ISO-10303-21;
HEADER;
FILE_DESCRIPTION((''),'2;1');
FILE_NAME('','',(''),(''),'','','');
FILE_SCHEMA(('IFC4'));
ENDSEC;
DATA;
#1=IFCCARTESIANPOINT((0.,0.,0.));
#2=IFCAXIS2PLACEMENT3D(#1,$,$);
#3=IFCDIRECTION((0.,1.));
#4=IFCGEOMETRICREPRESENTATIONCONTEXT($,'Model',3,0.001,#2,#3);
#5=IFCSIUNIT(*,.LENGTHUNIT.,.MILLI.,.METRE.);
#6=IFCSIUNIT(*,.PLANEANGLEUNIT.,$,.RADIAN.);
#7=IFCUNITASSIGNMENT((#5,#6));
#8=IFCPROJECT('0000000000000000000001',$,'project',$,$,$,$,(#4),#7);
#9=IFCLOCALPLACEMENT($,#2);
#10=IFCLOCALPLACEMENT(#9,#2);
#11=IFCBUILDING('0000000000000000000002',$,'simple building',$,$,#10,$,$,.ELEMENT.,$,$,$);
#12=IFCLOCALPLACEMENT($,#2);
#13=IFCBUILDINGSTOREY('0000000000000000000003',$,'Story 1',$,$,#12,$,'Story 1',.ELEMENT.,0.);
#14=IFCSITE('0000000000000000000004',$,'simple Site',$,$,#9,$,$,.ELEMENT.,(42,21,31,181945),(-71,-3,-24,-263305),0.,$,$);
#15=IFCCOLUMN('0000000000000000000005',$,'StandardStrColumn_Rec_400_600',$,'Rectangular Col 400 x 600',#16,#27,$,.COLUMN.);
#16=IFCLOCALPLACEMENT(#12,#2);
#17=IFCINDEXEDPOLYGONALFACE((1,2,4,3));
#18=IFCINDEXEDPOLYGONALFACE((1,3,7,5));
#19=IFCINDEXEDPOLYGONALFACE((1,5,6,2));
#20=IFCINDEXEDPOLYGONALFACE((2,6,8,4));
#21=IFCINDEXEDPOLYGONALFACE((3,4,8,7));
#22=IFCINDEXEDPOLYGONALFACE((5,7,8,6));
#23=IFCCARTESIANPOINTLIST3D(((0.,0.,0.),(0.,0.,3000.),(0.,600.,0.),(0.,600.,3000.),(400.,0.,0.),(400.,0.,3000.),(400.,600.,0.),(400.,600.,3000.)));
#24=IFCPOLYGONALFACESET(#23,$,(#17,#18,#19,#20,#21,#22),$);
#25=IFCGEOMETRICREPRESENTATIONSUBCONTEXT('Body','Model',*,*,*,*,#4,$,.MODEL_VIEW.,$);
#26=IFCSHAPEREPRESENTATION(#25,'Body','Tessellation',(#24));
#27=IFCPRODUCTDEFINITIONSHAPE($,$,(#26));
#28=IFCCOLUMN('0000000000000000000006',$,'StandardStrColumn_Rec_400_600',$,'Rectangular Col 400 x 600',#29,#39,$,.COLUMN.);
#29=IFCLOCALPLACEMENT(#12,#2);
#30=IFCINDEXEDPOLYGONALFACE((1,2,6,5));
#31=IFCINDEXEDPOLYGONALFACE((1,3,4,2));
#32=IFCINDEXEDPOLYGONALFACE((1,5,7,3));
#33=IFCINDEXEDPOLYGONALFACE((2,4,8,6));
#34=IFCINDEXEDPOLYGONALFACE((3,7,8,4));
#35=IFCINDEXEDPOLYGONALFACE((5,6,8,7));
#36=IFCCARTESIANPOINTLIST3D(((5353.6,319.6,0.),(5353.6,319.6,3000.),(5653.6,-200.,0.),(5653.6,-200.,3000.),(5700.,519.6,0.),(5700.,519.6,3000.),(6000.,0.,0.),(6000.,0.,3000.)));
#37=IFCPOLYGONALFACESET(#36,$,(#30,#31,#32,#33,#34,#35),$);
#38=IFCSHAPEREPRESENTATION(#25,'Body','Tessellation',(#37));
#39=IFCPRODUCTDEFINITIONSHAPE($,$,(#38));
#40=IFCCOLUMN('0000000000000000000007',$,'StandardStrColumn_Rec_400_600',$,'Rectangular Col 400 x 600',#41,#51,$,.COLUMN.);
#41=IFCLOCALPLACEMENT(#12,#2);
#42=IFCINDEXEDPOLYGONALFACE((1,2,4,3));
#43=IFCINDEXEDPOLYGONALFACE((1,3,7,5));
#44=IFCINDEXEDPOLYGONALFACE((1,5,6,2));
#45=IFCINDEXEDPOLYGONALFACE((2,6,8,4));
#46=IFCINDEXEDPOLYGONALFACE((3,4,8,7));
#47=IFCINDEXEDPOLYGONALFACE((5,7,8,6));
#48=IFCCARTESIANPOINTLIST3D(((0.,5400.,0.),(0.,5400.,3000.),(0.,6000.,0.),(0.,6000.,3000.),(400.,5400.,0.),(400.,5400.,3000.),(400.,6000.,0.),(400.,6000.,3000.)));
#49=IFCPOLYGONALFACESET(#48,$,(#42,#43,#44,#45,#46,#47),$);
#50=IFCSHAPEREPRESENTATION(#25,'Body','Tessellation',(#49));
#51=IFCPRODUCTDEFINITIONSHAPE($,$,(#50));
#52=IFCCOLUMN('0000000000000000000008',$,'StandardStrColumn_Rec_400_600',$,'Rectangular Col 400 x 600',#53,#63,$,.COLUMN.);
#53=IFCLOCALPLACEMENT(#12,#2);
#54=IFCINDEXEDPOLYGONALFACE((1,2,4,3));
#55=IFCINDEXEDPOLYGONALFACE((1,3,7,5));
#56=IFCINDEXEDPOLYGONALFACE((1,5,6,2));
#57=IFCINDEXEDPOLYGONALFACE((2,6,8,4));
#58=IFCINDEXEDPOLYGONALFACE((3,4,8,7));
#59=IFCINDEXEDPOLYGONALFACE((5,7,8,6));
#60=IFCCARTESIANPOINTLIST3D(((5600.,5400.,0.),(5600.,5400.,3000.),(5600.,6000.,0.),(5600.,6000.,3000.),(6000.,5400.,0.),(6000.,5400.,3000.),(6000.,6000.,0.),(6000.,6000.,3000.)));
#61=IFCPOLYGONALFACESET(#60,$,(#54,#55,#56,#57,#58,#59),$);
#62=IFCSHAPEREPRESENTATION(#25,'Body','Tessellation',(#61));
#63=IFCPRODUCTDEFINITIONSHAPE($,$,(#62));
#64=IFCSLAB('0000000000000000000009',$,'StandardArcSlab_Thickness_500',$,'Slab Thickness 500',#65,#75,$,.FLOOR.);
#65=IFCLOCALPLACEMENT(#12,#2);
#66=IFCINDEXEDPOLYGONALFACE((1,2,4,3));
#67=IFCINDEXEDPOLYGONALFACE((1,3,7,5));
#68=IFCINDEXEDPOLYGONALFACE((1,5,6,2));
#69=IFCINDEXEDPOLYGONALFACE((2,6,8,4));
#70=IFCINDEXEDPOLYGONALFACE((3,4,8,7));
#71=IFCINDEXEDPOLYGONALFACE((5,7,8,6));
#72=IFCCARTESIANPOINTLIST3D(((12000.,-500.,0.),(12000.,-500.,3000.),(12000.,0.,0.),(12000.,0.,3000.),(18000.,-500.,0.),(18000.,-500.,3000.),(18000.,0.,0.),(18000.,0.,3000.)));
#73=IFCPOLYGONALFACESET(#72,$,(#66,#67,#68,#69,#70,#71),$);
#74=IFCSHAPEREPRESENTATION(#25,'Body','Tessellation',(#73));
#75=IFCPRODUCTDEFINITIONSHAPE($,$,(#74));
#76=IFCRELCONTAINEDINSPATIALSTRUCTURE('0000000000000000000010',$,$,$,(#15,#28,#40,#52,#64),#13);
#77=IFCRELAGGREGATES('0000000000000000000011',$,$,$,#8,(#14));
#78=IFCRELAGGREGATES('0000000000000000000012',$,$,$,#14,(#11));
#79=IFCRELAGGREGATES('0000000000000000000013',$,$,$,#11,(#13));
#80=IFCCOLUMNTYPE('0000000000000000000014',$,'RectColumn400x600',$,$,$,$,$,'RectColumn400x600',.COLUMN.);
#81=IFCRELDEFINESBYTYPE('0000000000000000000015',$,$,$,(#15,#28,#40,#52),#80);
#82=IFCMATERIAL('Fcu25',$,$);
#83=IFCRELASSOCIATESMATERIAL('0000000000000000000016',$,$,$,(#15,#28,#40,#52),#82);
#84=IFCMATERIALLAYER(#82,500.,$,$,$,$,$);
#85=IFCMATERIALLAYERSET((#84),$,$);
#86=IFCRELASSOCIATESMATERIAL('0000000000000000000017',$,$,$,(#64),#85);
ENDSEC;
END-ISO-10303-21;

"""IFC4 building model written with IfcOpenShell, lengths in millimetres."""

from ifc_helpers import new_model, si_unit, direction, frame, origin, origin_with_axes, origin_2d_with_axis, place, context, subcontext, project, spatial, polyline, rectangle, outline, extrude, material, layer, layer_set, layer_usage, material_profile, profile_set, profile_usage, type_object, element, save


model = new_model("IFC4")

# Units and contexts
model_context = context("Model", 3, precision=0.001, world=origin(), true_north=direction((0.0, 1.0)))
body_context = subcontext(model_context, "Body", "Model", "MODEL_VIEW")
ifc_project = project(units=[si_unit("LENGTHUNIT", "METRE", prefix="MILLI"), si_unit("PLANEANGLEUNIT", "RADIAN")], contexts=[model_context])

# Site, building, storey
site_placement = place(None, origin())
site = spatial("IfcSite", under=ifc_project, at=site_placement, Name="simple Site", CompositionType="ELEMENT", RefLatitude=(42, 21, 31, 181945), RefLongitude=(-71, -3, -24, -263305), RefElevation=0.0)
building_placement = place(site_placement, origin())
building = spatial("IfcBuilding", under=site, at=building_placement, Name="simple building", CompositionType="ELEMENT")
storey_placement = place(None, origin())
storey = spatial("IfcBuildingStorey", under=building, at=storey_placement, Name="Story 1", LongName="Story 1", CompositionType="ELEMENT", Elevation=0.0)

# Columns
ifc_material = material(Name="Fcu25")
ifc_material_profile = material_profile(ifc_material, rectangle(XDim=400.0, YDim=600.0, at=origin_2d_with_axis()))
ifc_profile_set = profile_set([ifc_material_profile])
ifc_profile_usage_1 = profile_usage(ifc_profile_set, cardinal=7)
column_type = type_object("IfcColumnType", Name="RectColumn400x600", ElementType="RectColumn400x600", PredefinedType="COLUMN")
column_1_placement = place(None, frame((200.0, 300.0, 0.0), z_axis=(0.0, 0.0, 1.0), x_axis=(1.0, 0.0, 0.0)))
element("IfcColumn", 1, at=column_1_placement, inside=storey, type_object=column_type, material=ifc_profile_usage_1, Name="StandardStrColumn_Rec_400_600", ObjectType="Rectangular Col 400 x 600", PredefinedType="COLUMN", context=body_context, shape_type="SweptSolid", body=[
    extrude(rectangle(XDim=400.0, YDim=600.0, at=origin_2d_with_axis()), origin_with_axes(), (0.0, 0.0, 1.0), 3000.0),
])
ifc_profile_usage_2 = profile_usage(ifc_profile_set, cardinal=9)
column_2_placement = place(None, frame((5676.8, 159.8, 0.0), z_axis=(0.0, 0.0, 1.0), x_axis=(0.866025, 0.5, 0.0)))
element("IfcColumn", 2, at=column_2_placement, inside=storey, type_object=column_type, material=ifc_profile_usage_2, Name="StandardStrColumn_Rec_400_600", ObjectType="Rectangular Col 400 x 600", PredefinedType="COLUMN", context=body_context, shape_type="SweptSolid", body=[
    extrude(rectangle(XDim=400.0, YDim=600.0, at=origin_2d_with_axis()), origin_with_axes(), (0.0, 0.0, 1.0), 3000.0),
])
ifc_profile_usage_3 = profile_usage(ifc_profile_set, cardinal=1)
column_3_placement = place(None, frame((200.0, 5700.0, 0.0), z_axis=(0.0, 0.0, 1.0), x_axis=(1.0, 0.0, 0.0)))
element("IfcColumn", 3, at=column_3_placement, inside=storey, type_object=column_type, material=ifc_profile_usage_3, Name="StandardStrColumn_Rec_400_600", ObjectType="Rectangular Col 400 x 600", PredefinedType="COLUMN", context=body_context, shape_type="SweptSolid", body=[
    extrude(rectangle(XDim=400.0, YDim=600.0, at=origin_2d_with_axis()), origin_with_axes(), (0.0, 0.0, 1.0), 3000.0),
])
ifc_profile_usage_4 = profile_usage(ifc_profile_set, cardinal=3)
column_4_placement = place(None, frame((5800.0, 5700.0, 0.0), z_axis=(0.0, 0.0, 1.0), x_axis=(1.0, 0.0, 0.0)))
element("IfcColumn", 4, at=column_4_placement, inside=storey, type_object=column_type, material=ifc_profile_usage_4, Name="StandardStrColumn_Rec_400_600", ObjectType="Rectangular Col 400 x 600", PredefinedType="COLUMN", context=body_context, shape_type="SweptSolid", body=[
    extrude(rectangle(XDim=400.0, YDim=600.0, at=origin_2d_with_axis()), origin_with_axes(), (0.0, 0.0, 1.0), 3000.0),
])

# Slab
ifc_layer = layer(ifc_material, 500.0)
ifc_layer_set = layer_set([ifc_layer])
ifc_layer_usage = layer_usage(ifc_layer_set, "AXIS3", "POSITIVE", -500.0)
slab_placement = place(None, frame((12000.0, -500.0, 0.0), z_axis=(0.0, 1.0, 0.0), x_axis=(0.0, 0.0, 1.0)))
element("IfcSlab", 5, at=slab_placement, inside=storey, material=ifc_layer_usage, Name="StandardArcSlab_Thickness_500", ObjectType="Slab Thickness 500", PredefinedType="FLOOR", context=body_context, shape_type="SweptSolid", body=[
    extrude(outline(polyline([(0.0, 0.0), (3000.0, 0.0), (3000.0, 6000.0), (0.0, 6000.0), (0.0, 0.0)])), origin_with_axes(), (0.0, 0.0, 1.0), 500.0),
])

save(model, "model.ifc")
